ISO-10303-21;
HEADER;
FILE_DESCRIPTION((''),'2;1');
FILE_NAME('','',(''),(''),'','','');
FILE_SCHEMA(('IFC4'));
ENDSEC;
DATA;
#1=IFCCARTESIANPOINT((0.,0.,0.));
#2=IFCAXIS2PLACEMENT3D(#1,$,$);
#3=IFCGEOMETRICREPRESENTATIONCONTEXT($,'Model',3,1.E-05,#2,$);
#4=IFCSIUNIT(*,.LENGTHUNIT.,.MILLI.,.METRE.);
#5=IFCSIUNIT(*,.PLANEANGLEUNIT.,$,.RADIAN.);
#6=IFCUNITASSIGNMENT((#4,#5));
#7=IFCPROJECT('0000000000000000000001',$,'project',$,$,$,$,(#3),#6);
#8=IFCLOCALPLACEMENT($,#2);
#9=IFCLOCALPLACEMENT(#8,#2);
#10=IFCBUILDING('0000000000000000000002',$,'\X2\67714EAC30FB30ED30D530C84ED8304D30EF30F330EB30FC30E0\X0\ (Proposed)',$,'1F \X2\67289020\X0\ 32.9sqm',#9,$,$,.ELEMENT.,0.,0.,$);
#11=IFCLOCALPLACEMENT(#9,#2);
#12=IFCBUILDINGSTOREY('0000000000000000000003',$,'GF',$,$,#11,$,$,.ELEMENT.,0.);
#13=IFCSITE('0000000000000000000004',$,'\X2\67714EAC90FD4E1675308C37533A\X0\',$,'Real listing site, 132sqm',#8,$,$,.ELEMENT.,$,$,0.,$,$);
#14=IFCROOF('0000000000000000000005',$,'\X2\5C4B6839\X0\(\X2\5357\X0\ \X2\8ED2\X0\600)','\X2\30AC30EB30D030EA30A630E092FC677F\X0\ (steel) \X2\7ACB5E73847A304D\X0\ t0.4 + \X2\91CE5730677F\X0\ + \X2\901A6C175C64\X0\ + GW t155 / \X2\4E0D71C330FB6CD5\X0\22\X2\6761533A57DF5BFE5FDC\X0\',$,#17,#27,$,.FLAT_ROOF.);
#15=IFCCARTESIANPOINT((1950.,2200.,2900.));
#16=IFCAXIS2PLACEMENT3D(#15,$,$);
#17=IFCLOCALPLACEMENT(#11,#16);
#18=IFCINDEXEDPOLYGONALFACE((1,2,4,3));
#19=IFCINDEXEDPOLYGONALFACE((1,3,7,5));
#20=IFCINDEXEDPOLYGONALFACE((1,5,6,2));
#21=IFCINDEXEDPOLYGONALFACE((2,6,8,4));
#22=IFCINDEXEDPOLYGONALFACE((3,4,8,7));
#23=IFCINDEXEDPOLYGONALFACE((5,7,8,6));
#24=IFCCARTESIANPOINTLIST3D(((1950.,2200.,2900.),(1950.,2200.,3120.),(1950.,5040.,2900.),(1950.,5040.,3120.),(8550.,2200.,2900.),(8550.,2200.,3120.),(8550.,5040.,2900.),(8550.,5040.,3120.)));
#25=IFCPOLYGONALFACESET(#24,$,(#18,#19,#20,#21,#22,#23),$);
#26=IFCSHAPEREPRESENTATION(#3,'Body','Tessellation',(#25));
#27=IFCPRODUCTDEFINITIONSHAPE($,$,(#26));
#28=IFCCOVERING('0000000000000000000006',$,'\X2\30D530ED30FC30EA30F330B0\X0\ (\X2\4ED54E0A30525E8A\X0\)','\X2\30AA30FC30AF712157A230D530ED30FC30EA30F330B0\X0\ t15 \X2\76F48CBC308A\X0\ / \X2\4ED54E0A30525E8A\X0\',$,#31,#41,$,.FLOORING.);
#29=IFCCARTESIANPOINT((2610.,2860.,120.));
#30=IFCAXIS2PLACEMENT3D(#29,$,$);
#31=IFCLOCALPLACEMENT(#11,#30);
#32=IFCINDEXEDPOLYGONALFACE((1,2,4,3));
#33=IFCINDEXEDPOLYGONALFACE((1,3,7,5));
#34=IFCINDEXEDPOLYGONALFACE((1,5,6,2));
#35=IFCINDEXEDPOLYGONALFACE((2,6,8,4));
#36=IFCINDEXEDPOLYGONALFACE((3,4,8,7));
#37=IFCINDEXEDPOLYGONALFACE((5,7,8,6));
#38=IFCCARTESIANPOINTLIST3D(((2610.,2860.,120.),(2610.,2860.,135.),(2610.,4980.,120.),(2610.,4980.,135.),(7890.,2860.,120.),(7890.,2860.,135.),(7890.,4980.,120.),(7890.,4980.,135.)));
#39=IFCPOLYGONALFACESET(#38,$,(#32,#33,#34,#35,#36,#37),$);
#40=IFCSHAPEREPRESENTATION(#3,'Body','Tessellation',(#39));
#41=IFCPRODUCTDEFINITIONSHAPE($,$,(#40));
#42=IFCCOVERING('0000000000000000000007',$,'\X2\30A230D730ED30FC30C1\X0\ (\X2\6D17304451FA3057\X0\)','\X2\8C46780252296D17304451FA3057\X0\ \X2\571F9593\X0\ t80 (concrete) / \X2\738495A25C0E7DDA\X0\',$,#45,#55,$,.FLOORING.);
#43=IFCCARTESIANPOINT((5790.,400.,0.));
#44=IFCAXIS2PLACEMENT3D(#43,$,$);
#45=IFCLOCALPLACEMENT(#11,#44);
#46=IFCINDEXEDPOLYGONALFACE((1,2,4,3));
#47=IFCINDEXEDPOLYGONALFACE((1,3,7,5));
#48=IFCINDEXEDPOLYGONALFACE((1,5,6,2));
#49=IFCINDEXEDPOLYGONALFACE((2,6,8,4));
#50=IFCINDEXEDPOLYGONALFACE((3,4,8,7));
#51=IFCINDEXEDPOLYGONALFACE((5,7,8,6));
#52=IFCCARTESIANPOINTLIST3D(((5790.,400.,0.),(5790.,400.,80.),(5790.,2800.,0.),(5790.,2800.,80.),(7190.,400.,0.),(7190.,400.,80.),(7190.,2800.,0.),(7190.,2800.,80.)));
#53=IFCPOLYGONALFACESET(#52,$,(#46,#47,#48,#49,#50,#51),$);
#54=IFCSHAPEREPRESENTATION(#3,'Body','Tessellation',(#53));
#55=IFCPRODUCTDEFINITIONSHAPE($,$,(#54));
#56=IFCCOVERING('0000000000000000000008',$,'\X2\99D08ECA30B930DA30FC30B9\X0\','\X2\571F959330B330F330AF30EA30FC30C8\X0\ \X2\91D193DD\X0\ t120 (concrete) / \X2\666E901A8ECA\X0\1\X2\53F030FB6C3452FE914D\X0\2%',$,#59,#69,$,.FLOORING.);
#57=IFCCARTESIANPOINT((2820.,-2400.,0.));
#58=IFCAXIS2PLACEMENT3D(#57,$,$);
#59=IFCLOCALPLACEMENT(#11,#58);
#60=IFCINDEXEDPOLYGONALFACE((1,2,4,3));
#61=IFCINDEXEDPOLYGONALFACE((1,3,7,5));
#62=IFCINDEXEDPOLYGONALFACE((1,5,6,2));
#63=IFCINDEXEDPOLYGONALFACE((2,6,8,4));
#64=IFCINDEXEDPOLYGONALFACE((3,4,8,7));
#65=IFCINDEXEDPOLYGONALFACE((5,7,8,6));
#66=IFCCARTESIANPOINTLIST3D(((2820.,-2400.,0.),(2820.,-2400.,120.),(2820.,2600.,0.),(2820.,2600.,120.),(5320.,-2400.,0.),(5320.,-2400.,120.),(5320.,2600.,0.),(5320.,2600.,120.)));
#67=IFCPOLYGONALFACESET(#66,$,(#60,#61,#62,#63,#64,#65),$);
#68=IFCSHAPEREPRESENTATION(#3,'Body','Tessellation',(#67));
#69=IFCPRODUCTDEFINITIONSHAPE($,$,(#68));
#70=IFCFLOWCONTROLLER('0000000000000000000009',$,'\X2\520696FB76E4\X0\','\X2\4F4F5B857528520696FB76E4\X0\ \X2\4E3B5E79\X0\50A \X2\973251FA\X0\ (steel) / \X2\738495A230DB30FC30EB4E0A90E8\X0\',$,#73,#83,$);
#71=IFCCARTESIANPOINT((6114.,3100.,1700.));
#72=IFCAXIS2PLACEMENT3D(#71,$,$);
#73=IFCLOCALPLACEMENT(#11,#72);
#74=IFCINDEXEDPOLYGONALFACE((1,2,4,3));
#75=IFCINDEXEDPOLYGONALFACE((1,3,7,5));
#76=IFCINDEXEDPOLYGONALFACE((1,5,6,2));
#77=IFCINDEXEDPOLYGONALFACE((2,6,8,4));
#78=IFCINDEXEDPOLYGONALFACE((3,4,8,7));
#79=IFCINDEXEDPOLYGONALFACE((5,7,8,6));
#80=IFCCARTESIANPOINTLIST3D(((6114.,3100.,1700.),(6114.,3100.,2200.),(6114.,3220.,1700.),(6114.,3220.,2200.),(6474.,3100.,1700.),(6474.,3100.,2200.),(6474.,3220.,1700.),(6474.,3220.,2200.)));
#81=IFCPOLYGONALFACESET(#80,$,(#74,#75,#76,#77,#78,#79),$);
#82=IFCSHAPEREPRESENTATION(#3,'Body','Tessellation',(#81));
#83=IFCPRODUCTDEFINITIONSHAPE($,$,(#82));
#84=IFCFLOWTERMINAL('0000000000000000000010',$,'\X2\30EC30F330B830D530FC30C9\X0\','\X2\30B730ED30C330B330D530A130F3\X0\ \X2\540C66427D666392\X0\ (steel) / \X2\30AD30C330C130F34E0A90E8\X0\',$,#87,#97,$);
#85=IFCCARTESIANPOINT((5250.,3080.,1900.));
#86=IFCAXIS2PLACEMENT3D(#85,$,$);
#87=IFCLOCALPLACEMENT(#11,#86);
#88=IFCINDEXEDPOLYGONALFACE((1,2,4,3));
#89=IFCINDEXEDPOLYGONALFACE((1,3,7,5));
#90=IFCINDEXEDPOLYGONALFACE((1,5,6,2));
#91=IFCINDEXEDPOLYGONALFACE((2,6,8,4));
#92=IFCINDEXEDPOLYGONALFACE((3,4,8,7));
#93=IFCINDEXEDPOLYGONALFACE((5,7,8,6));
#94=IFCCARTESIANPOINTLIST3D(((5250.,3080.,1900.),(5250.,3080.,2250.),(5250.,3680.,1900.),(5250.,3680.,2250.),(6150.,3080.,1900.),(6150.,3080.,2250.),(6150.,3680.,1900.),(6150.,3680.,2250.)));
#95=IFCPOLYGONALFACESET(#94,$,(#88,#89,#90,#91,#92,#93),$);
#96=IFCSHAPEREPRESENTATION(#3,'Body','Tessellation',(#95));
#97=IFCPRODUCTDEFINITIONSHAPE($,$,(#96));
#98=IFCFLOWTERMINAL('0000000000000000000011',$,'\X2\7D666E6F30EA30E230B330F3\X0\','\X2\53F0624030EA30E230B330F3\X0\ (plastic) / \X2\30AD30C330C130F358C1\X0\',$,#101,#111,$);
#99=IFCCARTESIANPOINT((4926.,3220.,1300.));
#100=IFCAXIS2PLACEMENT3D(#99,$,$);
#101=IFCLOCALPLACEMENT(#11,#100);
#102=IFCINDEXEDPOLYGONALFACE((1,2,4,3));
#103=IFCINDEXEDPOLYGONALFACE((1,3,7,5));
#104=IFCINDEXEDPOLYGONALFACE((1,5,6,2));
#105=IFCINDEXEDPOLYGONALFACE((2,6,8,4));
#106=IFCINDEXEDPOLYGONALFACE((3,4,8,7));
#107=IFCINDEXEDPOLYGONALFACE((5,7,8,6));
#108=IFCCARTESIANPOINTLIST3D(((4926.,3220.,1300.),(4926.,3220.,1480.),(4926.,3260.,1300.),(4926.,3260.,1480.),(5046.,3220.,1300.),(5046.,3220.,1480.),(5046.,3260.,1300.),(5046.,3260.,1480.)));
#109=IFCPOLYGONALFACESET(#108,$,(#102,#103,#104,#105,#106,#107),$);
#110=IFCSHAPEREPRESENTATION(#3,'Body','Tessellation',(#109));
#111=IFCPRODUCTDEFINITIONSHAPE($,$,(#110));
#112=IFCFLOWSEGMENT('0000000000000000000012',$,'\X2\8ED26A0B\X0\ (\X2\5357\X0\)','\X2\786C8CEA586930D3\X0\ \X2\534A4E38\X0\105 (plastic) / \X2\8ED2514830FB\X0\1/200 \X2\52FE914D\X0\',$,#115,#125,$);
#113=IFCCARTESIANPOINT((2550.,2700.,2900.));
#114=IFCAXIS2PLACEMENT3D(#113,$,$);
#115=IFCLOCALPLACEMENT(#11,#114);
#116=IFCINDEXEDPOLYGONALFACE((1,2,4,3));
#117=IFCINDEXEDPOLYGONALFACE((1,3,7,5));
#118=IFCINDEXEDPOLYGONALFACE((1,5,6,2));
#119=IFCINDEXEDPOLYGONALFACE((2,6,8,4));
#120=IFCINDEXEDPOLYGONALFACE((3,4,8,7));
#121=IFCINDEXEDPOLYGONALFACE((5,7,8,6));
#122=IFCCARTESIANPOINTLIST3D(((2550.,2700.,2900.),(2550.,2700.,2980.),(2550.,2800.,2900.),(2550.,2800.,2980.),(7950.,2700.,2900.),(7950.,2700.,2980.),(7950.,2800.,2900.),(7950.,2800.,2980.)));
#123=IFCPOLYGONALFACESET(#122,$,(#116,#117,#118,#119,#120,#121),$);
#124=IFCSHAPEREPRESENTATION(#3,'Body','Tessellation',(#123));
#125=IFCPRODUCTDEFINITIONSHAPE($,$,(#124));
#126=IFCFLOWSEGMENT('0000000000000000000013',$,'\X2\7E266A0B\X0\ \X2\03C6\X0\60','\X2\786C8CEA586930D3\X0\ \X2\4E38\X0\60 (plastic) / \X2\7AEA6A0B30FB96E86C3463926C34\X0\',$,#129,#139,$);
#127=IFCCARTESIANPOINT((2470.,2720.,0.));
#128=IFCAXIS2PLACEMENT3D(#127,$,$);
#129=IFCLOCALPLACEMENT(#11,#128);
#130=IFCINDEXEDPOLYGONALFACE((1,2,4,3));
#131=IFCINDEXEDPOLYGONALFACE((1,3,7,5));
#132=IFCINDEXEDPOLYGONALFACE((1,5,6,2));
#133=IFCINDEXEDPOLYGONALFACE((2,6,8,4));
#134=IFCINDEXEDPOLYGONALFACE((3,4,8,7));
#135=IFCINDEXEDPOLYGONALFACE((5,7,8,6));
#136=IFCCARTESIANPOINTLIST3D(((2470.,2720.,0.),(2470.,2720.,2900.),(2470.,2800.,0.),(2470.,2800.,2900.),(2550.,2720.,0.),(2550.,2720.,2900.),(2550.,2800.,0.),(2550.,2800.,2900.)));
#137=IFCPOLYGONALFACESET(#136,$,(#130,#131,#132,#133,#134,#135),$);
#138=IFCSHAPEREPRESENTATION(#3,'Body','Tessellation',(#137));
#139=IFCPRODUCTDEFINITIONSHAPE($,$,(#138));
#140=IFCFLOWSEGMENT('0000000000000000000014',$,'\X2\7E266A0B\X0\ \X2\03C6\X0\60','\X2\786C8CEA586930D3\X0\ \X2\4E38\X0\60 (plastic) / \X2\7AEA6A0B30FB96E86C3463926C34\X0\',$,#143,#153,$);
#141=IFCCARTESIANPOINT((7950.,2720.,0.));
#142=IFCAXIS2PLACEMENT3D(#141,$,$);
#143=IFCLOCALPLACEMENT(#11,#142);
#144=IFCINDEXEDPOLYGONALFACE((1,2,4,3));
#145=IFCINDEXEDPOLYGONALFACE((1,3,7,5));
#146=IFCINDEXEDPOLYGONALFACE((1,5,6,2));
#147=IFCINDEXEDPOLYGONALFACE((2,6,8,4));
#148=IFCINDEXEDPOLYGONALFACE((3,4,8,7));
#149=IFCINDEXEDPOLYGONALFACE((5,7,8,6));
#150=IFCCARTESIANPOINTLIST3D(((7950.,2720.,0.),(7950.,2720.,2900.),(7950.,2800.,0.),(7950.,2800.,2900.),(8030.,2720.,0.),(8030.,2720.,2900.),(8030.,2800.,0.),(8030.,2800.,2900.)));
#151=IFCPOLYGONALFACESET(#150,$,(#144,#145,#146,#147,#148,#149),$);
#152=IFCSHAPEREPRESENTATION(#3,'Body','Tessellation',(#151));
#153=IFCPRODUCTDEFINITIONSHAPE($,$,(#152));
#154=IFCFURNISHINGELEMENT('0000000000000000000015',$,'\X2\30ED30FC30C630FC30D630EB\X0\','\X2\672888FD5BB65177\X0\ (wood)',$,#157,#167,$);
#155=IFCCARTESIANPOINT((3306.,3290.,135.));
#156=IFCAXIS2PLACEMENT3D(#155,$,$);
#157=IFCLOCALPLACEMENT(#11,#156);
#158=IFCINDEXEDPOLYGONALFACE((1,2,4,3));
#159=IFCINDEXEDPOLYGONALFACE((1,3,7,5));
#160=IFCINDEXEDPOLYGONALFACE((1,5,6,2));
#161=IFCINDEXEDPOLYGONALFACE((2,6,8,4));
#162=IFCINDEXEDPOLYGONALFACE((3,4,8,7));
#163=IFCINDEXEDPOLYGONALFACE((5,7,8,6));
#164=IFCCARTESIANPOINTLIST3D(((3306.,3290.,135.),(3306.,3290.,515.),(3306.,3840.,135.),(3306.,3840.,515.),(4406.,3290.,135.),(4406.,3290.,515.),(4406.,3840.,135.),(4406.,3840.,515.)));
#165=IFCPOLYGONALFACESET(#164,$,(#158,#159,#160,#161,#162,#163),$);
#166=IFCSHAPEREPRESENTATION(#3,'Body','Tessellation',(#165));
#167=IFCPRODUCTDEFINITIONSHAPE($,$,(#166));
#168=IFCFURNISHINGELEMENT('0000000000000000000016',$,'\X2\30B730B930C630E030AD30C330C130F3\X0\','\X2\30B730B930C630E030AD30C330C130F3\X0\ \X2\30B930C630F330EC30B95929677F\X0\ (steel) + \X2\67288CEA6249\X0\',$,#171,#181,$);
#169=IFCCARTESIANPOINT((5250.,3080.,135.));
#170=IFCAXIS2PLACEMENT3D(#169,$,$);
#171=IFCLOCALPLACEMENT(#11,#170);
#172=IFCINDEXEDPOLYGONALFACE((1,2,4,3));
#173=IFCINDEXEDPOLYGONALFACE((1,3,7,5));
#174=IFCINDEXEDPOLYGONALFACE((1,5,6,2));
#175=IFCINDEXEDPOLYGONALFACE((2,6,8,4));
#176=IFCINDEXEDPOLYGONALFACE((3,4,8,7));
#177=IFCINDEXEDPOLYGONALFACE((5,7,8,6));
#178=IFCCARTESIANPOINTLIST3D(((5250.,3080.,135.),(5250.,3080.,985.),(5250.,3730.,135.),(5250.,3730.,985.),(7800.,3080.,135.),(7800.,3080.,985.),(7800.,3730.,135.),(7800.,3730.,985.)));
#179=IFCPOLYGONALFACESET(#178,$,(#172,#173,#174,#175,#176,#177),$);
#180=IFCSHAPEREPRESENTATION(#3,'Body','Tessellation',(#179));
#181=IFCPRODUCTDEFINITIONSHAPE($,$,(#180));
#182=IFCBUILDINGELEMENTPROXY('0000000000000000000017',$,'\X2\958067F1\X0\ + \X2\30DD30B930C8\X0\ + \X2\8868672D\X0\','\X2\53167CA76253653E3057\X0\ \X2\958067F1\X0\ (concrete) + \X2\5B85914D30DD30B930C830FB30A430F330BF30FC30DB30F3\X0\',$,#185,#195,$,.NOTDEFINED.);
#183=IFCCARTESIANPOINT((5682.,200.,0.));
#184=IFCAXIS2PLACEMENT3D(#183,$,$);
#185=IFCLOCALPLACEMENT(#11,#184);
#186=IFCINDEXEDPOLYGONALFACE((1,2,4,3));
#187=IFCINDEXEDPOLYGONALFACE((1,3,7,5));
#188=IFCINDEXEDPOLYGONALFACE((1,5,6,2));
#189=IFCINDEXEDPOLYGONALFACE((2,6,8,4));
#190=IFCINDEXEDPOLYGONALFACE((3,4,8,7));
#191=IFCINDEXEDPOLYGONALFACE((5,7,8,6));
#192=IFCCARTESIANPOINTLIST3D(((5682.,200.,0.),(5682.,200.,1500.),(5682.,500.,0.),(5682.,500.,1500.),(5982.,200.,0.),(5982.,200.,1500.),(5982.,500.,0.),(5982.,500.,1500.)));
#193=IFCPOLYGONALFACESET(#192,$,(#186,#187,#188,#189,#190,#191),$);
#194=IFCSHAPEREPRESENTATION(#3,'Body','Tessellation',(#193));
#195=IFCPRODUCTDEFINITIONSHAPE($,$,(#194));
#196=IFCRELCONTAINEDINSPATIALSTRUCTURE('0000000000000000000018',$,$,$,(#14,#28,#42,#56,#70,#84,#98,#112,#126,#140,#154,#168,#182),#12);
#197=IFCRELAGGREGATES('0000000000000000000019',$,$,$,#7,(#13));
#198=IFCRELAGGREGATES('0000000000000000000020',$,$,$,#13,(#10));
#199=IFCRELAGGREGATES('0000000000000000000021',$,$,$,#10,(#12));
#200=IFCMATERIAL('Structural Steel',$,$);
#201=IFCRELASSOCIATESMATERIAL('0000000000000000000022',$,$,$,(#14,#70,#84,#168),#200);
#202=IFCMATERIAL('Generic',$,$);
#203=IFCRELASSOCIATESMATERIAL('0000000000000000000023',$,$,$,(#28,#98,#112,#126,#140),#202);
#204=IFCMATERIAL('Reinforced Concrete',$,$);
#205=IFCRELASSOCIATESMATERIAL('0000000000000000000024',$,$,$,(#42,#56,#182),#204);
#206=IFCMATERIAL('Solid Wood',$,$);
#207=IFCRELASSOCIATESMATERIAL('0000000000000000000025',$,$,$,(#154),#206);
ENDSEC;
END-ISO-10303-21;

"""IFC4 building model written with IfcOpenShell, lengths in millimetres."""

from ifc_helpers import new_model, si_unit, frame, frame_2d, origin, place, context, project, spatial, rectangle, extrude, material, element, save


model = new_model("IFC4")

# Units and contexts
model_context = context("Model", 3, precision=1e-05, world=origin())
ifc_project = project(units=[si_unit("LENGTHUNIT", "METRE", prefix="MILLI"), si_unit("PLANEANGLEUNIT", "RADIAN")], contexts=[model_context])

# Site, building, storey
site_placement = place(None, origin())
site = spatial("IfcSite", under=ifc_project, at=site_placement, Name="東京都世田谷区", ObjectType="Real listing site, 132sqm", CompositionType="ELEMENT", RefElevation=0.0)
building_placement = place(site_placement, origin())
building = spatial("IfcBuilding", under=site, at=building_placement, Name="東京・ロフト付きワンルーム (Proposed)", ObjectType="1F 木造 32.9sqm", CompositionType="ELEMENT", ElevationOfRefHeight=0.0, ElevationOfTerrain=0.0)
storey_placement = place(building_placement, origin())
storey = spatial("IfcBuildingStorey", under=building, at=storey_placement, Name="GF", CompositionType="ELEMENT", Elevation=0.0)

# Shared definitions
ifc_material_1 = material(Name="Solid Wood")

# Shared definitions
ifc_material_2 = material(Name="Reinforced Concrete")

# Roof
ifc_material_3 = material(Name="Structural Steel")
roof_placement = place(storey_placement, frame((1950.0, 2200.0, 2900.0)))
element("IfcRoof", 1, at=roof_placement, inside=storey, material=ifc_material_3, Name="屋根(南 軒600)", Description="ガルバリウム鋼板 (steel) 立平葺き t0.4 + 野地板 + 通気層 + GW t155 / 不燃・法22条区域対応", PredefinedType="FLAT_ROOF", context=model_context, shape_type="SweptSolid", body=[
    extrude(rectangle(XDim=6600.0, YDim=2840.0, at=frame_2d((3300.0, 1420.0))), frame((1950.0, 2200.0, 2900.0)), (0.0, 0.0, 1.0), 220.0),
])

# Coverings
ifc_material_4 = material(Name="Generic")
covering_1_placement = place(storey_placement, frame((2610.0, 2860.0, 120.0)))
element("IfcCovering", 2, at=covering_1_placement, inside=storey, material=ifc_material_4, Name="フローリング (仕上げ床)", Description="オーク無垢フローリング t15 直貼り / 仕上げ床", PredefinedType="FLOORING", context=model_context, shape_type="SweptSolid", body=[
    extrude(rectangle(XDim=5280.0, YDim=2120.0, at=frame_2d((2640.0, 1060.0))), frame((2610.0, 2860.0, 120.0)), (0.0, 0.0, 1.0), 15.0),
])
covering_2_placement = place(storey_placement, frame((5790.0, 400.0, 0.0)))
element("IfcCovering", 3, at=covering_2_placement, inside=storey, material=ifc_material_2, Name="アプローチ (洗い出し)", Description="豆砂利洗い出し 土間 t80 (concrete) / 玄関導線", PredefinedType="FLOORING", context=model_context, shape_type="SweptSolid", body=[
    extrude(rectangle(XDim=1400.0, YDim=2400.0, at=frame_2d((700.0, 1200.0))), frame((5790.0, 400.0, 0.0)), (0.0, 0.0, 1.0), 80.0),
])
covering_3_placement = place(storey_placement, frame((2820.0, -2400.0, 0.0)))
element("IfcCovering", 4, at=covering_3_placement, inside=storey, material=ifc_material_2, Name="駐車スペース", Description="土間コンクリート 金鏝 t120 (concrete) / 普通車1台・水勾配2%", PredefinedType="FLOORING", context=model_context, shape_type="SweptSolid", body=[
    extrude(rectangle(XDim=2500.0, YDim=5000.0, at=frame_2d((1250.0, 2500.0))), frame((2820.0, -2400.0, 0.0)), (0.0, 0.0, 1.0), 120.0),
])

# Flow controller
flow_controller_placement = place(storey_placement, frame((6114.0, 3100.0, 1700.0)))
element("IfcFlowController", 5, at=flow_controller_placement, inside=storey, material=ifc_material_3, Name="分電盤", Description="住宅用分電盤 主幹50A 露出 (steel) / 玄関ホール上部", context=model_context, shape_type="SweptSolid", body=[
    extrude(rectangle(XDim=360.0, YDim=120.0, at=frame_2d((180.0, 60.0))), frame((6114.0, 3100.0, 1700.0)), (0.0, 0.0, 1.0), 500.0),
])

# Flow terminals
flow_terminal_1_placement = place(storey_placement, frame((5250.0, 3080.0, 1900.0)))
element("IfcFlowTerminal", 6, at=flow_terminal_1_placement, inside=storey, material=ifc_material_3, Name="レンジフード", Description="シロッコファン 同時給排 (steel) / キッチン上部", context=model_context, shape_type="SweptSolid", body=[
    extrude(rectangle(XDim=900.0, YDim=600.0, at=frame_2d((450.0, 300.0))), frame((5250.0, 3080.0, 1900.0)), (0.0, 0.0, 1.0), 350.0),
])
flow_terminal_2_placement = place(storey_placement, frame((4926.0, 3220.0, 1300.0)))
element("IfcFlowTerminal", 7, at=flow_terminal_2_placement, inside=storey, material=ifc_material_4, Name="給湯リモコン", Description="台所リモコン (plastic) / キッチン壁", context=model_context, shape_type="SweptSolid", body=[
    extrude(rectangle(XDim=120.0, YDim=40.0, at=frame_2d((60.0, 20.0))), frame((4926.0, 3220.0, 1300.0)), (0.0, 0.0, 1.0), 180.0),
])

# Flow segments
flow_segment_1_placement = place(storey_placement, frame((2550.0, 2700.0, 2900.0)))
element("IfcFlowSegment", 8, at=flow_segment_1_placement, inside=storey, material=ifc_material_4, Name="軒樋 (南)", Description="硬質塩ビ 半丸105 (plastic) / 軒先・1/200 勾配", context=model_context, shape_type="SweptSolid", body=[
    extrude(rectangle(XDim=5400.0, YDim=100.0, at=frame_2d((2700.0, 50.0))), frame((2550.0, 2700.0, 2900.0)), (0.0, 0.0, 1.0), 80.0),
])
flow_segment_2_placement = place(storey_placement, frame((2470.0, 2720.0, 0.0)))
element("IfcFlowSegment", 9, at=flow_segment_2_placement, inside=storey, material=ifc_material_4, Name="縦樋 φ60", Description="硬質塩ビ 丸60 (plastic) / 竪樋・雨水排水", context=model_context, shape_type="SweptSolid", body=[
    extrude(rectangle(XDim=80.0, YDim=80.0, at=frame_2d((40.0, 40.0))), frame((2470.0, 2720.0, 0.0)), (0.0, 0.0, 1.0), 2900.0),
])
flow_segment_3_placement = place(storey_placement, frame((7950.0, 2720.0, 0.0)))
element("IfcFlowSegment", 10, at=flow_segment_3_placement, inside=storey, material=ifc_material_4, Name="縦樋 φ60", Description="硬質塩ビ 丸60 (plastic) / 竪樋・雨水排水", context=model_context, shape_type="SweptSolid", body=[
    extrude(rectangle(XDim=80.0, YDim=80.0, at=frame_2d((40.0, 40.0))), frame((7950.0, 2720.0, 0.0)), (0.0, 0.0, 1.0), 2900.0),
])

# Furnishing elements
furnishing_1_placement = place(storey_placement, frame((3306.0, 3290.0, 135.0)))
element("IfcFurnishingElement", 11, at=furnishing_1_placement, inside=storey, material=ifc_material_1, Name="ローテーブル", Description="木製家具 (wood)", context=model_context, shape_type="SweptSolid", body=[
    extrude(rectangle(XDim=1100.0, YDim=550.0, at=frame_2d((550.0, 275.0))), frame((3306.0, 3290.0, 135.0)), (0.0, 0.0, 1.0), 380.0),
])
furnishing_2_placement = place(storey_placement, frame((5250.0, 3080.0, 135.0)))
element("IfcFurnishingElement", 12, at=furnishing_2_placement, inside=storey, material=ifc_material_3, Name="システムキッチン", Description="システムキッチン ステンレス天板 (steel) + 木質扉", context=model_context, shape_type="SweptSolid", body=[
    extrude(rectangle(XDim=2550.0, YDim=650.0, at=frame_2d((1275.0, 325.0))), frame((5250.0, 3080.0, 135.0)), (0.0, 0.0, 1.0), 850.0),
])

# Building element proxy
proxy_placement = place(storey_placement, frame((5682.0, 200.0, 0.0)))
element("IfcBuildingElementProxy", 13, at=proxy_placement, inside=storey, material=ifc_material_2, Name="門柱 + ポスト + 表札", Description="化粧打放し 門柱 (concrete) + 宅配ポスト・インターホン", PredefinedType="NOTDEFINED", context=model_context, shape_type="SweptSolid", body=[
    extrude(rectangle(XDim=300.0, YDim=300.0, at=frame_2d((150.0, 150.0))), frame((5682.0, 200.0, 0.0)), (0.0, 0.0, 1.0), 1500.0),
])

save(model, "model.ifc")
